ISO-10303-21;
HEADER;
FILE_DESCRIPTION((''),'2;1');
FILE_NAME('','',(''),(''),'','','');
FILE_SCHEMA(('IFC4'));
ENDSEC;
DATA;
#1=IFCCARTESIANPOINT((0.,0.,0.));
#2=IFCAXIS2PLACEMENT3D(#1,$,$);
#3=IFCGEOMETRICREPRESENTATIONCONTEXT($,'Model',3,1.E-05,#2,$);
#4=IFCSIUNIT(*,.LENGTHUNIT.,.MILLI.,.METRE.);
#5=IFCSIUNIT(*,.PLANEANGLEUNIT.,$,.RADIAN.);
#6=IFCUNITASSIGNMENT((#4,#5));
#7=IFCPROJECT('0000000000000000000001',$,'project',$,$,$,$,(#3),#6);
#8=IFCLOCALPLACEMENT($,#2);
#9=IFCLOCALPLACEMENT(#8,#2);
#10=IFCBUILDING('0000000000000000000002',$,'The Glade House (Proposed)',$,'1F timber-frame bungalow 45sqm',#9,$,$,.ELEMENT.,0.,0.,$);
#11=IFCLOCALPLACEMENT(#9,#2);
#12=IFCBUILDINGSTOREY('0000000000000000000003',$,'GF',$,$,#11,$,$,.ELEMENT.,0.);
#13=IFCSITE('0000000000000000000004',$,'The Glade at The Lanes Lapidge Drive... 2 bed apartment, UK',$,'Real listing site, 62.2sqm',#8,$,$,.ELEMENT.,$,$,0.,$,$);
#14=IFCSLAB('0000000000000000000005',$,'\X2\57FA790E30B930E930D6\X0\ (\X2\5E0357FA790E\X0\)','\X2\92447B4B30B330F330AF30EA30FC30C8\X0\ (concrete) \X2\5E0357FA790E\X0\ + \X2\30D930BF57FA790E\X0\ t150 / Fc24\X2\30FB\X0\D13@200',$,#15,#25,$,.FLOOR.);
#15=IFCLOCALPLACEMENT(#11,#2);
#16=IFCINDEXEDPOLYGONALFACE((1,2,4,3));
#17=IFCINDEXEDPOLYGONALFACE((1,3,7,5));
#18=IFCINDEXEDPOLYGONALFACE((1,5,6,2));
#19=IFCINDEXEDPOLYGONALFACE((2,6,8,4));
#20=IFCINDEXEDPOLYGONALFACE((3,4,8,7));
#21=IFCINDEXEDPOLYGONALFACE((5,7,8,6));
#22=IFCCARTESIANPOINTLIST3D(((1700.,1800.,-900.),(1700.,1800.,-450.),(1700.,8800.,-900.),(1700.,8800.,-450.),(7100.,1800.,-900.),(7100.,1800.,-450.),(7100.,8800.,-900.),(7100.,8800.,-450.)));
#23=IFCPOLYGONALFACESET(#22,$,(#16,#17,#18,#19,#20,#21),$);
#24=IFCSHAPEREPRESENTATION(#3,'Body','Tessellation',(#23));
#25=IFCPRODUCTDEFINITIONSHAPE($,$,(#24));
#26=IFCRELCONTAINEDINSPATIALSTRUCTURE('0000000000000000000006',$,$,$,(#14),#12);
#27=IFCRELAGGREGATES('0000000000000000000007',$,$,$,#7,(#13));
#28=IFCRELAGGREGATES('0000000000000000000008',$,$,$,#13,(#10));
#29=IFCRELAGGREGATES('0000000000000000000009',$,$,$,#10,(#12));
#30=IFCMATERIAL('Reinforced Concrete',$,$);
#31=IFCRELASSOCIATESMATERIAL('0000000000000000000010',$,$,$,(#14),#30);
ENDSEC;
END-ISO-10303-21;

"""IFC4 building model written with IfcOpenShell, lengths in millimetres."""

from ifc_helpers import new_model, si_unit, frame, frame_2d, origin, place, context, project, spatial, rectangle, extrude, material, element, save


model = new_model("IFC4")

# Units and contexts
model_context = context("Model", 3, precision=1e-05, world=origin())
ifc_project = project(units=[si_unit("LENGTHUNIT", "METRE", prefix="MILLI"), si_unit("PLANEANGLEUNIT", "RADIAN")], contexts=[model_context])

# Site, building, storey
site_placement = place(None, origin())
site = spatial("IfcSite", under=ifc_project, at=site_placement, Name="The Glade at The Lanes Lapidge Drive... 2 bed apartment, UK", ObjectType="Real listing site, 62.2sqm", CompositionType="ELEMENT", RefElevation=0.0)
building_placement = place(site_placement, origin())
building = spatial("IfcBuilding", under=site, at=building_placement, Name="The Glade House (Proposed)", ObjectType="1F timber-frame bungalow 45sqm", CompositionType="ELEMENT", ElevationOfRefHeight=0.0, ElevationOfTerrain=0.0)
storey_placement = place(building_placement, origin())
storey = spatial("IfcBuildingStorey", under=building, at=storey_placement, Name="GF", CompositionType="ELEMENT", Elevation=0.0)

# Slab
ifc_material_1 = material(Name="Reinforced Concrete")
slab_1_placement = place(storey_placement, frame((850.0, 900.0, -450.0)))
element("IfcSlab", 1, at=slab_1_placement, inside=storey, material=ifc_material_1, Name="基礎スラブ (布基礎)", Description="鉄筋コンクリート (concrete) 布基礎 + ベタ基礎 t150 / Fc24・D13@200", PredefinedType="FLOOR", context=model_context, shape_type="SweptSolid", body=[
    extrude(rectangle(XDim=5400.0, YDim=7000.0, at=frame_2d((2700.0, 3500.0))), frame((850.0, 900.0, -450.0)), (0.0, 0.0, 1.0), 450.0),
])

save(model, "model.ifc")
